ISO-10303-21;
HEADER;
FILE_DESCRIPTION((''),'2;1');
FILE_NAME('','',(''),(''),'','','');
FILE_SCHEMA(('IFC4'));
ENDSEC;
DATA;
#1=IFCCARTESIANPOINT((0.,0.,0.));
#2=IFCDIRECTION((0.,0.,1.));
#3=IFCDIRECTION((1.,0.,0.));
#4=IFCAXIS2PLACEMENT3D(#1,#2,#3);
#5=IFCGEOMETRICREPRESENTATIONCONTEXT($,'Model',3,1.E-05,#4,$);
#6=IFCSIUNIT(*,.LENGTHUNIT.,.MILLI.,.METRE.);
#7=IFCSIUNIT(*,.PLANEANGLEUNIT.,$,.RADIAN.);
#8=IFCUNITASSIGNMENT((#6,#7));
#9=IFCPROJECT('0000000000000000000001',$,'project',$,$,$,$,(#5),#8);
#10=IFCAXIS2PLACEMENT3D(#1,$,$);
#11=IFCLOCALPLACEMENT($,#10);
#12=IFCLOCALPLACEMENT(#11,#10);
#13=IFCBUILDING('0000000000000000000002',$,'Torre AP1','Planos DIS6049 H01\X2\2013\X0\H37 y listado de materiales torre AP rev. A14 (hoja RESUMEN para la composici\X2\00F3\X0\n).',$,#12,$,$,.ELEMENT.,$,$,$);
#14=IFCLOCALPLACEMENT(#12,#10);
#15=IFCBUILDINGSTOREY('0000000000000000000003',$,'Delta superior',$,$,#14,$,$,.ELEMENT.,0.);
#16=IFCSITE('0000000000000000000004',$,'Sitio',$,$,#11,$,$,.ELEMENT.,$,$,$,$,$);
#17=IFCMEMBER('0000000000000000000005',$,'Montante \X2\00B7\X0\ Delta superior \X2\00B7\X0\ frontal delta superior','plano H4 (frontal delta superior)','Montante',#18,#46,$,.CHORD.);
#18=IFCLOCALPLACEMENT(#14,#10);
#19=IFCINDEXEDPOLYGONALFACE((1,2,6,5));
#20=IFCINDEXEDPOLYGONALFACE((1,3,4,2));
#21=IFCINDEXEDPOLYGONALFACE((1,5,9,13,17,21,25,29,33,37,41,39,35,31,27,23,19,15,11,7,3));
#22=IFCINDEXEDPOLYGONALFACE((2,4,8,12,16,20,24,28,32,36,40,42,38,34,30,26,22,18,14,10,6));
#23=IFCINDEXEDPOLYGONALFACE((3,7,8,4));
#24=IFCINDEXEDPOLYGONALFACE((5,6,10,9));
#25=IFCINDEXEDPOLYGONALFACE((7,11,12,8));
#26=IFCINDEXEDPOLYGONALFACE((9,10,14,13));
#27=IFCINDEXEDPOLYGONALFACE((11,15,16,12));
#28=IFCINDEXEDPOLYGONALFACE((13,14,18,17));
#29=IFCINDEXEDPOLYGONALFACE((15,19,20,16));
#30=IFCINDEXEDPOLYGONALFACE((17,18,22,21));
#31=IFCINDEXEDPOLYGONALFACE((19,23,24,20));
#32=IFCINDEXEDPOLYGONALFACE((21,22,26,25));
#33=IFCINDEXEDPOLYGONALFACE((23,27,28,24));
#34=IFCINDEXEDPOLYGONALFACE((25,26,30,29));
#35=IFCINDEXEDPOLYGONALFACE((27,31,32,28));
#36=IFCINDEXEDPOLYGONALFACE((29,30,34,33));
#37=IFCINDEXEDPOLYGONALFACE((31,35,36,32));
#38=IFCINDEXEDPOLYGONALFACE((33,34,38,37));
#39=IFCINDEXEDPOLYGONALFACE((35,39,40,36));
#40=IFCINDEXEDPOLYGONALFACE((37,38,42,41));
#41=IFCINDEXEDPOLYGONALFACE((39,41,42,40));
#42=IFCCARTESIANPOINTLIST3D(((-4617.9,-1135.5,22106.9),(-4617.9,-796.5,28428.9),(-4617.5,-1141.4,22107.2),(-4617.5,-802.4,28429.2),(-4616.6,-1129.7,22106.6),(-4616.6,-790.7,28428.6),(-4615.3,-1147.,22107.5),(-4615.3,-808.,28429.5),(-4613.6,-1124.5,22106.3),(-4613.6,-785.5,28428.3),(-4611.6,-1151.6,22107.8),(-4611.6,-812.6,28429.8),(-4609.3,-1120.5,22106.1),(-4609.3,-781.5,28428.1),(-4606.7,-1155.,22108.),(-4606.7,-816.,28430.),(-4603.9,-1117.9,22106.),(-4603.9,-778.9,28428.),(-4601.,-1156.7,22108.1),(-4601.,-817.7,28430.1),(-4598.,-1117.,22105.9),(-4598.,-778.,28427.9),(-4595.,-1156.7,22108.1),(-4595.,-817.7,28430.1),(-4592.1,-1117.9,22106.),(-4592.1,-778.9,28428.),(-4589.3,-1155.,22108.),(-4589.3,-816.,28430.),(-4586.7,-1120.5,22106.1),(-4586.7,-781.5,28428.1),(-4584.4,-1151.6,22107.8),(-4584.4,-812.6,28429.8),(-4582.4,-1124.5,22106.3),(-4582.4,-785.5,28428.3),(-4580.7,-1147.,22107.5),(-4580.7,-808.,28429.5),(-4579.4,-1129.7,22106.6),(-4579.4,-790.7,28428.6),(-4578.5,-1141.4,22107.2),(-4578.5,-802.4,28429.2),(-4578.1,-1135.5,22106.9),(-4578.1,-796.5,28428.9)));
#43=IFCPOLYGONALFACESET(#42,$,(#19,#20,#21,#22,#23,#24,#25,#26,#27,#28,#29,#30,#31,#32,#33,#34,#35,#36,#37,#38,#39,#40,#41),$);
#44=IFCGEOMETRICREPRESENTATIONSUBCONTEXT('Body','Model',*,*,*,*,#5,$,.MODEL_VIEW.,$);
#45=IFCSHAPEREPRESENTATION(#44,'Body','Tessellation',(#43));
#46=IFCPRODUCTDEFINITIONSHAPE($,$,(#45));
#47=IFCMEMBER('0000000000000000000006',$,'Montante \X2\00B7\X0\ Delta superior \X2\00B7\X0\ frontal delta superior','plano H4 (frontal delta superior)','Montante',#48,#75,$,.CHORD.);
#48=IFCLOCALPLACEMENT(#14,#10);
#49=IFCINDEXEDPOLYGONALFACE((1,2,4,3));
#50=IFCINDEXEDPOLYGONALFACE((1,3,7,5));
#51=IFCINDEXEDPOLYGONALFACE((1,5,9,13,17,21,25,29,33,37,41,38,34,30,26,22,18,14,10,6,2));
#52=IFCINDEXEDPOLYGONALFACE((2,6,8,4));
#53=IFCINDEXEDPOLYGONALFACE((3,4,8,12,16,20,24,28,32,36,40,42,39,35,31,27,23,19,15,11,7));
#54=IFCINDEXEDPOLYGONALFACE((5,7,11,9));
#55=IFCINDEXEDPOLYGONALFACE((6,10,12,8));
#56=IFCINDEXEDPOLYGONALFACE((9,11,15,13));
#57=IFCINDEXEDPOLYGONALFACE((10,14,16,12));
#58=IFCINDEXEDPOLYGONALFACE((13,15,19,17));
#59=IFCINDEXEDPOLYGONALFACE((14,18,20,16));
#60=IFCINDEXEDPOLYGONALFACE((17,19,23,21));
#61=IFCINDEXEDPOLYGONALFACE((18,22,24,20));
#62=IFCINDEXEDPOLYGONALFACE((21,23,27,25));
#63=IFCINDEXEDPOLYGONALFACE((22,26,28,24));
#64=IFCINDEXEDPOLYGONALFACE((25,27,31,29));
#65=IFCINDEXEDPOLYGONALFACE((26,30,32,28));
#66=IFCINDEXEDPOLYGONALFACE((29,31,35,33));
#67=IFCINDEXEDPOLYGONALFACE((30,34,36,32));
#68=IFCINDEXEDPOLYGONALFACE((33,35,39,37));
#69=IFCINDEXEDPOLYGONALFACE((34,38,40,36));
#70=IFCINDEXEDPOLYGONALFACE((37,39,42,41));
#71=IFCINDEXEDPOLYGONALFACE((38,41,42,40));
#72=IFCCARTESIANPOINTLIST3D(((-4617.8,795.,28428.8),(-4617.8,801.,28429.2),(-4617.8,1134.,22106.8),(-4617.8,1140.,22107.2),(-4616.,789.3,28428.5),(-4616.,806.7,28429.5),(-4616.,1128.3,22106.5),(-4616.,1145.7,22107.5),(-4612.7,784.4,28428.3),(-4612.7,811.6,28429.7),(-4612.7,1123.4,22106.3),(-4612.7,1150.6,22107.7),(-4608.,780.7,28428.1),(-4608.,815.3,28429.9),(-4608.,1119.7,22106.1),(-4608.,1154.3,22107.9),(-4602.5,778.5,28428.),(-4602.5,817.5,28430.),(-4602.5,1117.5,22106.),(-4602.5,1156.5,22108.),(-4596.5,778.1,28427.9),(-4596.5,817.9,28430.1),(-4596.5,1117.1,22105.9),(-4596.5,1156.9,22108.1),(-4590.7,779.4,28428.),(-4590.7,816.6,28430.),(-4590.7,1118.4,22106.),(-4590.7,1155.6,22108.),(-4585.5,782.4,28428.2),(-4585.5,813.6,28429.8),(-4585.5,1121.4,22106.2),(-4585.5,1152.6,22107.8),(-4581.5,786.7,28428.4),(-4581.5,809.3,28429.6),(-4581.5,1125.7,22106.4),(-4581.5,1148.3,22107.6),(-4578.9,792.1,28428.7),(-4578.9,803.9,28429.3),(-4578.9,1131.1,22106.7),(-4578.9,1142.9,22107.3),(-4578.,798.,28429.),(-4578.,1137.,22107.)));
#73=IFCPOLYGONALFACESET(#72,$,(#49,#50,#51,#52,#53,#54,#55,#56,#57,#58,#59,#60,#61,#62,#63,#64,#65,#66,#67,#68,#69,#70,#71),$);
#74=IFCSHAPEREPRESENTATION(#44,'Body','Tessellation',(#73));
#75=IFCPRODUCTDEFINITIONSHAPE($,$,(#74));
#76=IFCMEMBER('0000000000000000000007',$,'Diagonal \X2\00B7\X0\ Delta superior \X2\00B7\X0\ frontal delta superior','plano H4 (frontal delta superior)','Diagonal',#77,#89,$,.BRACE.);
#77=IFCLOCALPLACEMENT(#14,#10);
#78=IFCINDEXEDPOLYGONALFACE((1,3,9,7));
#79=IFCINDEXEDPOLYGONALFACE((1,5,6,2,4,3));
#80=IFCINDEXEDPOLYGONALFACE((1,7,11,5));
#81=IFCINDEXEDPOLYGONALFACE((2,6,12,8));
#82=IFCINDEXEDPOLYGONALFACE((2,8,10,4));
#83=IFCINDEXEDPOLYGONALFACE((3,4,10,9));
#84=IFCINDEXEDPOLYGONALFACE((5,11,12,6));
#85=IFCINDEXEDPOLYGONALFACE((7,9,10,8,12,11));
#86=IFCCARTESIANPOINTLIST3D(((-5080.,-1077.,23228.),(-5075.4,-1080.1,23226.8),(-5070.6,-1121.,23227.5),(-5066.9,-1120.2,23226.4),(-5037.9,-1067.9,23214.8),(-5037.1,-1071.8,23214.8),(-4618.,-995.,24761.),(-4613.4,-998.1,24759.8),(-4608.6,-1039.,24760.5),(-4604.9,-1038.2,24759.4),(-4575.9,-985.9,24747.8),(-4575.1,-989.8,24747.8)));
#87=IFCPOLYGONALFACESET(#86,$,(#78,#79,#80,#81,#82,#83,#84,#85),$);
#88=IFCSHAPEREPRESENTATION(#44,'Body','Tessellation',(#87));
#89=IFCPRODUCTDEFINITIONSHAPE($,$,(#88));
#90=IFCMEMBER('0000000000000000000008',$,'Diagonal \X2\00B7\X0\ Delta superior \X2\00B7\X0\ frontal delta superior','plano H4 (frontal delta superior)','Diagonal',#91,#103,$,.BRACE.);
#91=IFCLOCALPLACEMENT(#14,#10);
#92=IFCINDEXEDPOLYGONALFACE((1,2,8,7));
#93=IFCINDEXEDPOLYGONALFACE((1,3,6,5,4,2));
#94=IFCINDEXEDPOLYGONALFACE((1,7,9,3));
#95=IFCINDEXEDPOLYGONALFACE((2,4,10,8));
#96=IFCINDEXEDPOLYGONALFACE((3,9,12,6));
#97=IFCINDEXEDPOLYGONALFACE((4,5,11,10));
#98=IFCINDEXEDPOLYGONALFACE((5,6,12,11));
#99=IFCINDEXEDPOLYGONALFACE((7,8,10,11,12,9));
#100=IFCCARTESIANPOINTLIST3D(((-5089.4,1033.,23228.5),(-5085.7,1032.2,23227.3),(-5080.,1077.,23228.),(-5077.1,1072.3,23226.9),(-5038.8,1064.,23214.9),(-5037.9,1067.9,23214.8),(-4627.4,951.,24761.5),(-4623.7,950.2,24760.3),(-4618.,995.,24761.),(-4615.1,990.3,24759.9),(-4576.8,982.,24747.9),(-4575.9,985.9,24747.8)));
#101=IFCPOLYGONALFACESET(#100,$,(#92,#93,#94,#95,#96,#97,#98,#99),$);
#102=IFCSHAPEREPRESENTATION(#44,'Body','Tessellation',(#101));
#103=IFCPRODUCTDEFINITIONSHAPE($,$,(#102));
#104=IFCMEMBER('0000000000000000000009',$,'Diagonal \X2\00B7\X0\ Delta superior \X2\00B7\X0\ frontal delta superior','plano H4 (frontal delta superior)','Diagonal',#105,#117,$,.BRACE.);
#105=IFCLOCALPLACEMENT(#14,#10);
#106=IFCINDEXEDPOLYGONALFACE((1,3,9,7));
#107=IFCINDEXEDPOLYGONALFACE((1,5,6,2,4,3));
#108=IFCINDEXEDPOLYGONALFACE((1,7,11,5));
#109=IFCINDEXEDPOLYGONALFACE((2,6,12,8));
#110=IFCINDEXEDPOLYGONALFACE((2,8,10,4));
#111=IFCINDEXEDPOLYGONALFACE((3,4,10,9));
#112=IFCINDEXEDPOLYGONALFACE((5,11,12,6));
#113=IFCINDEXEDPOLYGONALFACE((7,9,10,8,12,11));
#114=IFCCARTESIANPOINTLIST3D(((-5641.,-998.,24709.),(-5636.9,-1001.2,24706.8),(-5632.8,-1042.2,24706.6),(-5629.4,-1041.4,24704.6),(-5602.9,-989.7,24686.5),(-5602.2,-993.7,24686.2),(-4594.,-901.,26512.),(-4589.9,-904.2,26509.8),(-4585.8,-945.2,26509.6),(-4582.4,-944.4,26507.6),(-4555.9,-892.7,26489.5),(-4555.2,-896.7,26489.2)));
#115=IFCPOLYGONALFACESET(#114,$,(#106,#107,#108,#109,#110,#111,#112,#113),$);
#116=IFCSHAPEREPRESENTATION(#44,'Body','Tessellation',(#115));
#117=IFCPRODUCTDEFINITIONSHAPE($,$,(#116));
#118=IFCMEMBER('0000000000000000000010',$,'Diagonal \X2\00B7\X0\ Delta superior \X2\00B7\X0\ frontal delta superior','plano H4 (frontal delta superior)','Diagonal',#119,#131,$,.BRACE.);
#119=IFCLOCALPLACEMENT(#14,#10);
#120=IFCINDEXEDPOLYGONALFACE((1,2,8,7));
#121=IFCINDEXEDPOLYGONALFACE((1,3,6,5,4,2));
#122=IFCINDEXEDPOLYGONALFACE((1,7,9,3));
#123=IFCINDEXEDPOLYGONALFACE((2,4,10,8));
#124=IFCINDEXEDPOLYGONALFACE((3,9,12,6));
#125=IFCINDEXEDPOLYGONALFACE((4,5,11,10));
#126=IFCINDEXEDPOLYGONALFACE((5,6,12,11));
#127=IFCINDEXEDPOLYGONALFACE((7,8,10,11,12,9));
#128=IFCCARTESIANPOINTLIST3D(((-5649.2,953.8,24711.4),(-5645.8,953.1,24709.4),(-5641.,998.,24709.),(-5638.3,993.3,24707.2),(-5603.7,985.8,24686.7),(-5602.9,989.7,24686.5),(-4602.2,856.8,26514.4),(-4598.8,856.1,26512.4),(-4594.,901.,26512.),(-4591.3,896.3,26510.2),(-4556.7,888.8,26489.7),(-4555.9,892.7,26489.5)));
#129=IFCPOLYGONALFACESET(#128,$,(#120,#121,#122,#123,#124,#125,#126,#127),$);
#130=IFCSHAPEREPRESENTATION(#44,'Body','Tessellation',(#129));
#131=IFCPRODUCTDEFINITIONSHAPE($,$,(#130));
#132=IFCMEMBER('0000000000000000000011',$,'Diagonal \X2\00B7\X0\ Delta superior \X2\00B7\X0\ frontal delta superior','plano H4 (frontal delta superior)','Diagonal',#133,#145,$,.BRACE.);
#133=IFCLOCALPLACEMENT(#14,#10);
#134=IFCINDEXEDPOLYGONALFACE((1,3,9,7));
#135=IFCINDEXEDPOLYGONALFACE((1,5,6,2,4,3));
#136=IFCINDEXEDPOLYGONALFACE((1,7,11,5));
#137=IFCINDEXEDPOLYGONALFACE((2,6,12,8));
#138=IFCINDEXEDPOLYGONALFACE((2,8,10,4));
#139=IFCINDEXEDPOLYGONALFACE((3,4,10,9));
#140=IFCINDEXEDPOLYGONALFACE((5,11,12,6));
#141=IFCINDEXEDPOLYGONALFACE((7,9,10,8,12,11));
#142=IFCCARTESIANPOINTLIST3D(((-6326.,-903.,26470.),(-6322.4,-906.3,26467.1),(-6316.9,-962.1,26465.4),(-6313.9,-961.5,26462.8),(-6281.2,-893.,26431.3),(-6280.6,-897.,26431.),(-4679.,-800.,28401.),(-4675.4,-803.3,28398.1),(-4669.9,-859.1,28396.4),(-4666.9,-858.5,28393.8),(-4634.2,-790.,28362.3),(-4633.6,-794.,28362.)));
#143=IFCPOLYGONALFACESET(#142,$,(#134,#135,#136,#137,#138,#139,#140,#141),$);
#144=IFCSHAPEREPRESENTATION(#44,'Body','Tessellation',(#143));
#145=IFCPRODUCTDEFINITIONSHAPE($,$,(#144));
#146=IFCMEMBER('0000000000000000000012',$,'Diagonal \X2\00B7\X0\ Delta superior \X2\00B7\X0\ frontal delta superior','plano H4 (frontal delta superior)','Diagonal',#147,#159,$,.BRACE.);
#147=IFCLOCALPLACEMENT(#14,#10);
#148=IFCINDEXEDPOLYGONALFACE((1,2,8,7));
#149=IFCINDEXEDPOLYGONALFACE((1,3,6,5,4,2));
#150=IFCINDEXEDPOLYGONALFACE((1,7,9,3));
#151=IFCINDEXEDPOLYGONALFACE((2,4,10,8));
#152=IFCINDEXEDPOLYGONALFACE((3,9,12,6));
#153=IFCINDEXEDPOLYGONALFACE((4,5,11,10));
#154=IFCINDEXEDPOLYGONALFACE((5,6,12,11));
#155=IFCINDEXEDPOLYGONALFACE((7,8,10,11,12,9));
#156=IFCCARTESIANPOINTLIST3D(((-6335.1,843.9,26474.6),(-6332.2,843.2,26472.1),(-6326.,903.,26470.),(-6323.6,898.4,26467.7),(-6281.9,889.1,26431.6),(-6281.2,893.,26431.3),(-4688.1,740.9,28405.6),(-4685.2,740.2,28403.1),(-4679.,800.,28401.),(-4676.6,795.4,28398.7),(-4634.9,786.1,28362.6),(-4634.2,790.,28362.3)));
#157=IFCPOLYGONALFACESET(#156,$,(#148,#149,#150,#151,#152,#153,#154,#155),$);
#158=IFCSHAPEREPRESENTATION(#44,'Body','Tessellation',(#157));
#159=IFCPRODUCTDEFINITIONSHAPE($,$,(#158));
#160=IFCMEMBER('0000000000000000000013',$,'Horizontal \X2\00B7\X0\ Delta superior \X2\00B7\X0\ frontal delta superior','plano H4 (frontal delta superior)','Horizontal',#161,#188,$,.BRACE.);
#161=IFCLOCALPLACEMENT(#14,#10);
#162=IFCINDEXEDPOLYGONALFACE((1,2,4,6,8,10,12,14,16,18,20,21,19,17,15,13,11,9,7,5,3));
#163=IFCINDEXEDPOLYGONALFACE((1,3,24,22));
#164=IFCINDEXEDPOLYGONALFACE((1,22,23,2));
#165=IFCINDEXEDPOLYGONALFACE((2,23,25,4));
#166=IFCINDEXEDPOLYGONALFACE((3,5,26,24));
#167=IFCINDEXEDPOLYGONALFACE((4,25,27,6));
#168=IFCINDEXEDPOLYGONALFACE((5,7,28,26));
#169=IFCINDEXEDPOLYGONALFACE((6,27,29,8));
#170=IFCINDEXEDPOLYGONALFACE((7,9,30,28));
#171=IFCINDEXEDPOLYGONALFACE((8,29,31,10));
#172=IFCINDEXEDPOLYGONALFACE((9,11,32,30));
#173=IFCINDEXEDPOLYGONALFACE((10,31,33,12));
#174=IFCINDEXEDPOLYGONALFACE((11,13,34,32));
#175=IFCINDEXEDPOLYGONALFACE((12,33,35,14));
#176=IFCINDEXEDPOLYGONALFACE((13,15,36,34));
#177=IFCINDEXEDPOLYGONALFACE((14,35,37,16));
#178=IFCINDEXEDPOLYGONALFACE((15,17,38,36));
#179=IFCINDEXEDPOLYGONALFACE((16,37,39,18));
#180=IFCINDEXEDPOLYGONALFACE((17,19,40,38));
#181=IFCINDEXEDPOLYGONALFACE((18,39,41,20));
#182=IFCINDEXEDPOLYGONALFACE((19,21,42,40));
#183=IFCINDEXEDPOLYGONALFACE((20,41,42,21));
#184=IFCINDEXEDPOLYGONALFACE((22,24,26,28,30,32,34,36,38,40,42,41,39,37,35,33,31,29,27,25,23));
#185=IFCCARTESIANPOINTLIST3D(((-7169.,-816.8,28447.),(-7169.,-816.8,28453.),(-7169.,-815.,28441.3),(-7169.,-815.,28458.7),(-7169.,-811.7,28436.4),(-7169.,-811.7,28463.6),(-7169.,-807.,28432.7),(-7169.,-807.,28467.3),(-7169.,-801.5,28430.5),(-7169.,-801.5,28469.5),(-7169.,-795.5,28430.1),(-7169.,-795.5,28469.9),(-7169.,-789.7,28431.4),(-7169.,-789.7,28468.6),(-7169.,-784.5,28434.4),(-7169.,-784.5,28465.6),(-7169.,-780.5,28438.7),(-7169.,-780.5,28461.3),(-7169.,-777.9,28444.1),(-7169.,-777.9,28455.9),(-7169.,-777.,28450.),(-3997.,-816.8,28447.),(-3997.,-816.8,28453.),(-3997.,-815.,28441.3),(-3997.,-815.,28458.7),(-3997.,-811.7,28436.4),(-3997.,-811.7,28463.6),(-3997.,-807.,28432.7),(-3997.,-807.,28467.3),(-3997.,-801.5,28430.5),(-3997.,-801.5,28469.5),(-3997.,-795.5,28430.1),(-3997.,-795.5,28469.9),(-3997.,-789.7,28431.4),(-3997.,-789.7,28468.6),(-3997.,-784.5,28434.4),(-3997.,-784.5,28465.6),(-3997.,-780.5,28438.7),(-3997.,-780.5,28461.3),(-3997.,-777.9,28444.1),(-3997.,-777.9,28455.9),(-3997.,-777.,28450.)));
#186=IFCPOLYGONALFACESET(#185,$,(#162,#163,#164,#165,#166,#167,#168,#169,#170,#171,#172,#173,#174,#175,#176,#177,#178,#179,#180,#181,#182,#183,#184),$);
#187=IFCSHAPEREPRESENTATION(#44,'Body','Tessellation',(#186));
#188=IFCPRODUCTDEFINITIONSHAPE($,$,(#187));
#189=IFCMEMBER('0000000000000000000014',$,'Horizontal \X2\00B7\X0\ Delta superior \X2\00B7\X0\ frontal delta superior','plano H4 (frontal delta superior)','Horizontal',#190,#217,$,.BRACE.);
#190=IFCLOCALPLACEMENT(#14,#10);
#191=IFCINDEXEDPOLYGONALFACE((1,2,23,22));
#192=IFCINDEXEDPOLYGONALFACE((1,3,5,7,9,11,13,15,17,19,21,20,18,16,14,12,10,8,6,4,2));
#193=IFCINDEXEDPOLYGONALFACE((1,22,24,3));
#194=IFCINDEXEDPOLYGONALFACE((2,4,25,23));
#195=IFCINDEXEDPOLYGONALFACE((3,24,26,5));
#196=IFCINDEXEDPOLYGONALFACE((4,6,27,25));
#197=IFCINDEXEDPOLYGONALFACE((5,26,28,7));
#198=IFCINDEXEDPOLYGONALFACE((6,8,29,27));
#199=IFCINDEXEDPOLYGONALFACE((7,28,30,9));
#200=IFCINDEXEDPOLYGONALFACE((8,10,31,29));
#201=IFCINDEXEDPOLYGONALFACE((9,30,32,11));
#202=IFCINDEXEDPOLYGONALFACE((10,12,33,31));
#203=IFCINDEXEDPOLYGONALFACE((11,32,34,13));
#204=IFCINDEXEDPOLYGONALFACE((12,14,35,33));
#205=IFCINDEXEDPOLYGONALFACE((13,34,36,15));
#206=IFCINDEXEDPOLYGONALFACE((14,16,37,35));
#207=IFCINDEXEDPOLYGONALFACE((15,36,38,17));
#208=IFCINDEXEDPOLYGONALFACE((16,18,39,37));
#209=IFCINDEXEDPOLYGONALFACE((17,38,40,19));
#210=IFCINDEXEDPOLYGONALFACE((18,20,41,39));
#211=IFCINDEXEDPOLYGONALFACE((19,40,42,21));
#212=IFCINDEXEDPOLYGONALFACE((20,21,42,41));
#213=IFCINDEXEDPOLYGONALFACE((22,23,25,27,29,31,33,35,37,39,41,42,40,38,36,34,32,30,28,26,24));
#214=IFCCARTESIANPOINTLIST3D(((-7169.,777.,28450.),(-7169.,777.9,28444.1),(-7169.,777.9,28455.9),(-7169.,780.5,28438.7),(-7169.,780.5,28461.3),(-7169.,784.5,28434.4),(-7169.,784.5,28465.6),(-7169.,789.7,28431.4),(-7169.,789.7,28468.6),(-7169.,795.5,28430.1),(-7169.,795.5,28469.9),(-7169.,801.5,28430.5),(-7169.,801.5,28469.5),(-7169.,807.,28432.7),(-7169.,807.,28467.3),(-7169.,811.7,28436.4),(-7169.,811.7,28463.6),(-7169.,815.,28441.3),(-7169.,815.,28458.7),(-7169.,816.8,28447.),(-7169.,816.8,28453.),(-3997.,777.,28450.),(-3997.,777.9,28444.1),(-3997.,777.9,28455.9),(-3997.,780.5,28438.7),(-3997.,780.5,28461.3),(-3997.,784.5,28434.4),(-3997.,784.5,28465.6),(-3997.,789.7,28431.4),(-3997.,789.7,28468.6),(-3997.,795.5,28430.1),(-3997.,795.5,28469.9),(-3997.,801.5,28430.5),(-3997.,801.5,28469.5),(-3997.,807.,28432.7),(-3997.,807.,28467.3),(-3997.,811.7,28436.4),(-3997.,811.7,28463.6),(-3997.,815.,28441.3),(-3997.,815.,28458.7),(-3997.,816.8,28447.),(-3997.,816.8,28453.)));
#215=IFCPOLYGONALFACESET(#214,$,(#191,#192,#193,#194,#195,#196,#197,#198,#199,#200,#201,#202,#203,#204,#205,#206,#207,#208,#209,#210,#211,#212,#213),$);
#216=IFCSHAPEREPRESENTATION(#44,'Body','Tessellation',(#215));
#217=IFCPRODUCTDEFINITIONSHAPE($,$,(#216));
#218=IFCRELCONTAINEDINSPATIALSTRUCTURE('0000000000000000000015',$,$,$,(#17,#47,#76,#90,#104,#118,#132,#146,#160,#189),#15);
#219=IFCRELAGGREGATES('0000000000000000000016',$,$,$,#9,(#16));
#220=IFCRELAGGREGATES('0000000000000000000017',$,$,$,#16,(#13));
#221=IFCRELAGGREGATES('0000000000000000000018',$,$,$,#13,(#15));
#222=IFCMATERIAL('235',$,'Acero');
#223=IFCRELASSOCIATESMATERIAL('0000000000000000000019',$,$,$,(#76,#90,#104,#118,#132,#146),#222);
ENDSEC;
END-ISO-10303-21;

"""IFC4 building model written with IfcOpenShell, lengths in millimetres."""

from ifc_helpers import new_model, si_unit, frame, frame_2d, origin, origin_with_axes, place, context, subcontext, project, spatial, circle, l_section, extrude, material, element, save


model = new_model("IFC4")

# Units and contexts
model_context = context("Model", 3, precision=1e-05, world=origin_with_axes())
body_context = subcontext(model_context, "Body", "Model", "MODEL_VIEW")
ifc_project = project(units=[si_unit("LENGTHUNIT", "METRE", prefix="MILLI"), si_unit("PLANEANGLEUNIT", "RADIAN")], contexts=[model_context])

# Site, building, storey
site_placement = place(None, origin())
site = spatial("IfcSite", under=ifc_project, at=site_placement, Name="Sitio", CompositionType="ELEMENT")
building_placement = place(site_placement, origin())
building = spatial("IfcBuilding", under=site, at=building_placement, Name="Torre AP1", Description="Planos DIS6049 H01–H37 y listado de materiales torre AP rev. A14 (hoja RESUMEN para la composición).", CompositionType="ELEMENT")
storey_placement = place(building_placement, origin())
storey = spatial("IfcBuildingStorey", under=building, at=storey_placement, Name="Delta superior", CompositionType="ELEMENT", Elevation=0.0)

# Members
for number, where, z_axis, x_axis, name in (
    (1, (-4598.0, -798.0, 28429.0), (0.0, -0.053545, -0.998565), (0.0, 0.998565, -0.053545), "Montante · Delta superior · frontal delta superior"),
    (2, (-4598.0, 798.0, 28429.0), (0.0, 0.053545, -0.998565), (1.0, 0.0, 0.0), "Montante · Delta superior · frontal delta superior"),
):
    element("IfcMember", number, at=place(storey_placement, frame(where, z_axis=z_axis, x_axis=x_axis)), inside=storey, Name=name, Description="plano H4 (frontal delta superior)", ObjectType="Montante", PredefinedType="CHORD", context=body_context, shape_type="SweptSolid", body=[
        extrude(circle(Radius=20.0), None, (0.0, 0.0, 1.0), 6331.1),
    ])
ifc_material_1 = material(Name="235", Category="Acero")
for number, where, z_axis, x_axis, name in (
    (3, (-4618.0, -995.0, 24761.0), (-0.288173, -0.051148, -0.956211), (0.934509, 0.202848, -0.292483), "Diagonal · Delta superior · frontal delta superior"),
    (4, (-4618.0, 995.0, 24761.0), (-0.288173, 0.051148, -0.956211), (0.934509, -0.202848, -0.292483), "Diagonal · Delta superior · frontal delta superior"),
):
    element("IfcMember", number, at=place(storey_placement, frame(where, z_axis=z_axis, x_axis=x_axis)), inside=storey, material=ifc_material_1, Name=name, Description="plano H4 (frontal delta superior)", ObjectType="Diagonal", PredefinedType="BRACE", context=body_context, shape_type="SweptSolid", body=[
        extrude(l_section(Depth=45.0, Width=45.0, Thickness=4.0, at=frame_2d((22.5, 22.5))), None, (0.0, 0.0, 1.0), 1603.2),
    ])
for number, where, z_axis, x_axis, name in (
    (5, (-4594.0, -901.0, 26512.0), (-0.501628, -0.046474, -0.863834), (0.845685, 0.183933, -0.500984), "Diagonal · Delta superior · frontal delta superior"),
    (6, (-4594.0, 901.0, 26512.0), (-0.501628, 0.046474, -0.863834), (0.845685, -0.183933, -0.500984), "Diagonal · Delta superior · frontal delta superior"),
):
    element("IfcMember", number, at=place(storey_placement, frame(where, z_axis=z_axis, x_axis=x_axis)), inside=storey, material=ifc_material_1, Name=name, Description="plano H4 (frontal delta superior)", ObjectType="Diagonal", PredefinedType="BRACE", context=body_context, shape_type="SweptSolid", body=[
        extrude(l_section(Depth=45.0, Width=45.0, Thickness=4.0, at=frame_2d((22.5, 22.5))), None, (0.0, 0.0, 1.0), 2087.2),
    ])
for number, where, z_axis, x_axis, name in (
    (7, (-4679.0, -800.0, 28401.0), (-0.648406, -0.04055, -0.760214), (0.745871, 0.166153, -0.645035), "Diagonal · Delta superior · frontal delta superior"),
    (8, (-4679.0, 800.0, 28401.0), (-0.648406, 0.04055, -0.760214), (0.745871, -0.166153, -0.645035), "Diagonal · Delta superior · frontal delta superior"),
):
    element("IfcMember", number, at=place(storey_placement, frame(where, z_axis=z_axis, x_axis=x_axis)), inside=storey, material=ifc_material_1, Name=name, Description="plano H4 (frontal delta superior)", ObjectType="Diagonal", PredefinedType="BRACE", context=body_context, shape_type="SweptSolid", body=[
        extrude(l_section(Depth=60.0, Width=60.0, Thickness=4.0, at=frame_2d((30.0, 30.0))), None, (0.0, 0.0, 1.0), 2540.1),
    ])
for number, where, z_axis, x_axis, name in (
    (9, (-3997.0, -797.0, 28450.0), (-1.0, 0.0, 0.0), (0.0, 1.0, 0.0), "Horizontal · Delta superior · frontal delta superior"),
    (10, (-3997.0, 797.0, 28450.0), (-1.0, 0.0, 0.0), (0.0, -1.0, 0.0), "Horizontal · Delta superior · frontal delta superior"),
):
    element("IfcMember", number, at=place(storey_placement, frame(where, z_axis=z_axis, x_axis=x_axis)), inside=storey, Name=name, Description="plano H4 (frontal delta superior)", ObjectType="Horizontal", PredefinedType="BRACE", context=body_context, shape_type="SweptSolid", body=[
        extrude(circle(Radius=20.0), None, (0.0, 0.0, 1.0), 3172.0),
    ])

save(model, "model.ifc")
